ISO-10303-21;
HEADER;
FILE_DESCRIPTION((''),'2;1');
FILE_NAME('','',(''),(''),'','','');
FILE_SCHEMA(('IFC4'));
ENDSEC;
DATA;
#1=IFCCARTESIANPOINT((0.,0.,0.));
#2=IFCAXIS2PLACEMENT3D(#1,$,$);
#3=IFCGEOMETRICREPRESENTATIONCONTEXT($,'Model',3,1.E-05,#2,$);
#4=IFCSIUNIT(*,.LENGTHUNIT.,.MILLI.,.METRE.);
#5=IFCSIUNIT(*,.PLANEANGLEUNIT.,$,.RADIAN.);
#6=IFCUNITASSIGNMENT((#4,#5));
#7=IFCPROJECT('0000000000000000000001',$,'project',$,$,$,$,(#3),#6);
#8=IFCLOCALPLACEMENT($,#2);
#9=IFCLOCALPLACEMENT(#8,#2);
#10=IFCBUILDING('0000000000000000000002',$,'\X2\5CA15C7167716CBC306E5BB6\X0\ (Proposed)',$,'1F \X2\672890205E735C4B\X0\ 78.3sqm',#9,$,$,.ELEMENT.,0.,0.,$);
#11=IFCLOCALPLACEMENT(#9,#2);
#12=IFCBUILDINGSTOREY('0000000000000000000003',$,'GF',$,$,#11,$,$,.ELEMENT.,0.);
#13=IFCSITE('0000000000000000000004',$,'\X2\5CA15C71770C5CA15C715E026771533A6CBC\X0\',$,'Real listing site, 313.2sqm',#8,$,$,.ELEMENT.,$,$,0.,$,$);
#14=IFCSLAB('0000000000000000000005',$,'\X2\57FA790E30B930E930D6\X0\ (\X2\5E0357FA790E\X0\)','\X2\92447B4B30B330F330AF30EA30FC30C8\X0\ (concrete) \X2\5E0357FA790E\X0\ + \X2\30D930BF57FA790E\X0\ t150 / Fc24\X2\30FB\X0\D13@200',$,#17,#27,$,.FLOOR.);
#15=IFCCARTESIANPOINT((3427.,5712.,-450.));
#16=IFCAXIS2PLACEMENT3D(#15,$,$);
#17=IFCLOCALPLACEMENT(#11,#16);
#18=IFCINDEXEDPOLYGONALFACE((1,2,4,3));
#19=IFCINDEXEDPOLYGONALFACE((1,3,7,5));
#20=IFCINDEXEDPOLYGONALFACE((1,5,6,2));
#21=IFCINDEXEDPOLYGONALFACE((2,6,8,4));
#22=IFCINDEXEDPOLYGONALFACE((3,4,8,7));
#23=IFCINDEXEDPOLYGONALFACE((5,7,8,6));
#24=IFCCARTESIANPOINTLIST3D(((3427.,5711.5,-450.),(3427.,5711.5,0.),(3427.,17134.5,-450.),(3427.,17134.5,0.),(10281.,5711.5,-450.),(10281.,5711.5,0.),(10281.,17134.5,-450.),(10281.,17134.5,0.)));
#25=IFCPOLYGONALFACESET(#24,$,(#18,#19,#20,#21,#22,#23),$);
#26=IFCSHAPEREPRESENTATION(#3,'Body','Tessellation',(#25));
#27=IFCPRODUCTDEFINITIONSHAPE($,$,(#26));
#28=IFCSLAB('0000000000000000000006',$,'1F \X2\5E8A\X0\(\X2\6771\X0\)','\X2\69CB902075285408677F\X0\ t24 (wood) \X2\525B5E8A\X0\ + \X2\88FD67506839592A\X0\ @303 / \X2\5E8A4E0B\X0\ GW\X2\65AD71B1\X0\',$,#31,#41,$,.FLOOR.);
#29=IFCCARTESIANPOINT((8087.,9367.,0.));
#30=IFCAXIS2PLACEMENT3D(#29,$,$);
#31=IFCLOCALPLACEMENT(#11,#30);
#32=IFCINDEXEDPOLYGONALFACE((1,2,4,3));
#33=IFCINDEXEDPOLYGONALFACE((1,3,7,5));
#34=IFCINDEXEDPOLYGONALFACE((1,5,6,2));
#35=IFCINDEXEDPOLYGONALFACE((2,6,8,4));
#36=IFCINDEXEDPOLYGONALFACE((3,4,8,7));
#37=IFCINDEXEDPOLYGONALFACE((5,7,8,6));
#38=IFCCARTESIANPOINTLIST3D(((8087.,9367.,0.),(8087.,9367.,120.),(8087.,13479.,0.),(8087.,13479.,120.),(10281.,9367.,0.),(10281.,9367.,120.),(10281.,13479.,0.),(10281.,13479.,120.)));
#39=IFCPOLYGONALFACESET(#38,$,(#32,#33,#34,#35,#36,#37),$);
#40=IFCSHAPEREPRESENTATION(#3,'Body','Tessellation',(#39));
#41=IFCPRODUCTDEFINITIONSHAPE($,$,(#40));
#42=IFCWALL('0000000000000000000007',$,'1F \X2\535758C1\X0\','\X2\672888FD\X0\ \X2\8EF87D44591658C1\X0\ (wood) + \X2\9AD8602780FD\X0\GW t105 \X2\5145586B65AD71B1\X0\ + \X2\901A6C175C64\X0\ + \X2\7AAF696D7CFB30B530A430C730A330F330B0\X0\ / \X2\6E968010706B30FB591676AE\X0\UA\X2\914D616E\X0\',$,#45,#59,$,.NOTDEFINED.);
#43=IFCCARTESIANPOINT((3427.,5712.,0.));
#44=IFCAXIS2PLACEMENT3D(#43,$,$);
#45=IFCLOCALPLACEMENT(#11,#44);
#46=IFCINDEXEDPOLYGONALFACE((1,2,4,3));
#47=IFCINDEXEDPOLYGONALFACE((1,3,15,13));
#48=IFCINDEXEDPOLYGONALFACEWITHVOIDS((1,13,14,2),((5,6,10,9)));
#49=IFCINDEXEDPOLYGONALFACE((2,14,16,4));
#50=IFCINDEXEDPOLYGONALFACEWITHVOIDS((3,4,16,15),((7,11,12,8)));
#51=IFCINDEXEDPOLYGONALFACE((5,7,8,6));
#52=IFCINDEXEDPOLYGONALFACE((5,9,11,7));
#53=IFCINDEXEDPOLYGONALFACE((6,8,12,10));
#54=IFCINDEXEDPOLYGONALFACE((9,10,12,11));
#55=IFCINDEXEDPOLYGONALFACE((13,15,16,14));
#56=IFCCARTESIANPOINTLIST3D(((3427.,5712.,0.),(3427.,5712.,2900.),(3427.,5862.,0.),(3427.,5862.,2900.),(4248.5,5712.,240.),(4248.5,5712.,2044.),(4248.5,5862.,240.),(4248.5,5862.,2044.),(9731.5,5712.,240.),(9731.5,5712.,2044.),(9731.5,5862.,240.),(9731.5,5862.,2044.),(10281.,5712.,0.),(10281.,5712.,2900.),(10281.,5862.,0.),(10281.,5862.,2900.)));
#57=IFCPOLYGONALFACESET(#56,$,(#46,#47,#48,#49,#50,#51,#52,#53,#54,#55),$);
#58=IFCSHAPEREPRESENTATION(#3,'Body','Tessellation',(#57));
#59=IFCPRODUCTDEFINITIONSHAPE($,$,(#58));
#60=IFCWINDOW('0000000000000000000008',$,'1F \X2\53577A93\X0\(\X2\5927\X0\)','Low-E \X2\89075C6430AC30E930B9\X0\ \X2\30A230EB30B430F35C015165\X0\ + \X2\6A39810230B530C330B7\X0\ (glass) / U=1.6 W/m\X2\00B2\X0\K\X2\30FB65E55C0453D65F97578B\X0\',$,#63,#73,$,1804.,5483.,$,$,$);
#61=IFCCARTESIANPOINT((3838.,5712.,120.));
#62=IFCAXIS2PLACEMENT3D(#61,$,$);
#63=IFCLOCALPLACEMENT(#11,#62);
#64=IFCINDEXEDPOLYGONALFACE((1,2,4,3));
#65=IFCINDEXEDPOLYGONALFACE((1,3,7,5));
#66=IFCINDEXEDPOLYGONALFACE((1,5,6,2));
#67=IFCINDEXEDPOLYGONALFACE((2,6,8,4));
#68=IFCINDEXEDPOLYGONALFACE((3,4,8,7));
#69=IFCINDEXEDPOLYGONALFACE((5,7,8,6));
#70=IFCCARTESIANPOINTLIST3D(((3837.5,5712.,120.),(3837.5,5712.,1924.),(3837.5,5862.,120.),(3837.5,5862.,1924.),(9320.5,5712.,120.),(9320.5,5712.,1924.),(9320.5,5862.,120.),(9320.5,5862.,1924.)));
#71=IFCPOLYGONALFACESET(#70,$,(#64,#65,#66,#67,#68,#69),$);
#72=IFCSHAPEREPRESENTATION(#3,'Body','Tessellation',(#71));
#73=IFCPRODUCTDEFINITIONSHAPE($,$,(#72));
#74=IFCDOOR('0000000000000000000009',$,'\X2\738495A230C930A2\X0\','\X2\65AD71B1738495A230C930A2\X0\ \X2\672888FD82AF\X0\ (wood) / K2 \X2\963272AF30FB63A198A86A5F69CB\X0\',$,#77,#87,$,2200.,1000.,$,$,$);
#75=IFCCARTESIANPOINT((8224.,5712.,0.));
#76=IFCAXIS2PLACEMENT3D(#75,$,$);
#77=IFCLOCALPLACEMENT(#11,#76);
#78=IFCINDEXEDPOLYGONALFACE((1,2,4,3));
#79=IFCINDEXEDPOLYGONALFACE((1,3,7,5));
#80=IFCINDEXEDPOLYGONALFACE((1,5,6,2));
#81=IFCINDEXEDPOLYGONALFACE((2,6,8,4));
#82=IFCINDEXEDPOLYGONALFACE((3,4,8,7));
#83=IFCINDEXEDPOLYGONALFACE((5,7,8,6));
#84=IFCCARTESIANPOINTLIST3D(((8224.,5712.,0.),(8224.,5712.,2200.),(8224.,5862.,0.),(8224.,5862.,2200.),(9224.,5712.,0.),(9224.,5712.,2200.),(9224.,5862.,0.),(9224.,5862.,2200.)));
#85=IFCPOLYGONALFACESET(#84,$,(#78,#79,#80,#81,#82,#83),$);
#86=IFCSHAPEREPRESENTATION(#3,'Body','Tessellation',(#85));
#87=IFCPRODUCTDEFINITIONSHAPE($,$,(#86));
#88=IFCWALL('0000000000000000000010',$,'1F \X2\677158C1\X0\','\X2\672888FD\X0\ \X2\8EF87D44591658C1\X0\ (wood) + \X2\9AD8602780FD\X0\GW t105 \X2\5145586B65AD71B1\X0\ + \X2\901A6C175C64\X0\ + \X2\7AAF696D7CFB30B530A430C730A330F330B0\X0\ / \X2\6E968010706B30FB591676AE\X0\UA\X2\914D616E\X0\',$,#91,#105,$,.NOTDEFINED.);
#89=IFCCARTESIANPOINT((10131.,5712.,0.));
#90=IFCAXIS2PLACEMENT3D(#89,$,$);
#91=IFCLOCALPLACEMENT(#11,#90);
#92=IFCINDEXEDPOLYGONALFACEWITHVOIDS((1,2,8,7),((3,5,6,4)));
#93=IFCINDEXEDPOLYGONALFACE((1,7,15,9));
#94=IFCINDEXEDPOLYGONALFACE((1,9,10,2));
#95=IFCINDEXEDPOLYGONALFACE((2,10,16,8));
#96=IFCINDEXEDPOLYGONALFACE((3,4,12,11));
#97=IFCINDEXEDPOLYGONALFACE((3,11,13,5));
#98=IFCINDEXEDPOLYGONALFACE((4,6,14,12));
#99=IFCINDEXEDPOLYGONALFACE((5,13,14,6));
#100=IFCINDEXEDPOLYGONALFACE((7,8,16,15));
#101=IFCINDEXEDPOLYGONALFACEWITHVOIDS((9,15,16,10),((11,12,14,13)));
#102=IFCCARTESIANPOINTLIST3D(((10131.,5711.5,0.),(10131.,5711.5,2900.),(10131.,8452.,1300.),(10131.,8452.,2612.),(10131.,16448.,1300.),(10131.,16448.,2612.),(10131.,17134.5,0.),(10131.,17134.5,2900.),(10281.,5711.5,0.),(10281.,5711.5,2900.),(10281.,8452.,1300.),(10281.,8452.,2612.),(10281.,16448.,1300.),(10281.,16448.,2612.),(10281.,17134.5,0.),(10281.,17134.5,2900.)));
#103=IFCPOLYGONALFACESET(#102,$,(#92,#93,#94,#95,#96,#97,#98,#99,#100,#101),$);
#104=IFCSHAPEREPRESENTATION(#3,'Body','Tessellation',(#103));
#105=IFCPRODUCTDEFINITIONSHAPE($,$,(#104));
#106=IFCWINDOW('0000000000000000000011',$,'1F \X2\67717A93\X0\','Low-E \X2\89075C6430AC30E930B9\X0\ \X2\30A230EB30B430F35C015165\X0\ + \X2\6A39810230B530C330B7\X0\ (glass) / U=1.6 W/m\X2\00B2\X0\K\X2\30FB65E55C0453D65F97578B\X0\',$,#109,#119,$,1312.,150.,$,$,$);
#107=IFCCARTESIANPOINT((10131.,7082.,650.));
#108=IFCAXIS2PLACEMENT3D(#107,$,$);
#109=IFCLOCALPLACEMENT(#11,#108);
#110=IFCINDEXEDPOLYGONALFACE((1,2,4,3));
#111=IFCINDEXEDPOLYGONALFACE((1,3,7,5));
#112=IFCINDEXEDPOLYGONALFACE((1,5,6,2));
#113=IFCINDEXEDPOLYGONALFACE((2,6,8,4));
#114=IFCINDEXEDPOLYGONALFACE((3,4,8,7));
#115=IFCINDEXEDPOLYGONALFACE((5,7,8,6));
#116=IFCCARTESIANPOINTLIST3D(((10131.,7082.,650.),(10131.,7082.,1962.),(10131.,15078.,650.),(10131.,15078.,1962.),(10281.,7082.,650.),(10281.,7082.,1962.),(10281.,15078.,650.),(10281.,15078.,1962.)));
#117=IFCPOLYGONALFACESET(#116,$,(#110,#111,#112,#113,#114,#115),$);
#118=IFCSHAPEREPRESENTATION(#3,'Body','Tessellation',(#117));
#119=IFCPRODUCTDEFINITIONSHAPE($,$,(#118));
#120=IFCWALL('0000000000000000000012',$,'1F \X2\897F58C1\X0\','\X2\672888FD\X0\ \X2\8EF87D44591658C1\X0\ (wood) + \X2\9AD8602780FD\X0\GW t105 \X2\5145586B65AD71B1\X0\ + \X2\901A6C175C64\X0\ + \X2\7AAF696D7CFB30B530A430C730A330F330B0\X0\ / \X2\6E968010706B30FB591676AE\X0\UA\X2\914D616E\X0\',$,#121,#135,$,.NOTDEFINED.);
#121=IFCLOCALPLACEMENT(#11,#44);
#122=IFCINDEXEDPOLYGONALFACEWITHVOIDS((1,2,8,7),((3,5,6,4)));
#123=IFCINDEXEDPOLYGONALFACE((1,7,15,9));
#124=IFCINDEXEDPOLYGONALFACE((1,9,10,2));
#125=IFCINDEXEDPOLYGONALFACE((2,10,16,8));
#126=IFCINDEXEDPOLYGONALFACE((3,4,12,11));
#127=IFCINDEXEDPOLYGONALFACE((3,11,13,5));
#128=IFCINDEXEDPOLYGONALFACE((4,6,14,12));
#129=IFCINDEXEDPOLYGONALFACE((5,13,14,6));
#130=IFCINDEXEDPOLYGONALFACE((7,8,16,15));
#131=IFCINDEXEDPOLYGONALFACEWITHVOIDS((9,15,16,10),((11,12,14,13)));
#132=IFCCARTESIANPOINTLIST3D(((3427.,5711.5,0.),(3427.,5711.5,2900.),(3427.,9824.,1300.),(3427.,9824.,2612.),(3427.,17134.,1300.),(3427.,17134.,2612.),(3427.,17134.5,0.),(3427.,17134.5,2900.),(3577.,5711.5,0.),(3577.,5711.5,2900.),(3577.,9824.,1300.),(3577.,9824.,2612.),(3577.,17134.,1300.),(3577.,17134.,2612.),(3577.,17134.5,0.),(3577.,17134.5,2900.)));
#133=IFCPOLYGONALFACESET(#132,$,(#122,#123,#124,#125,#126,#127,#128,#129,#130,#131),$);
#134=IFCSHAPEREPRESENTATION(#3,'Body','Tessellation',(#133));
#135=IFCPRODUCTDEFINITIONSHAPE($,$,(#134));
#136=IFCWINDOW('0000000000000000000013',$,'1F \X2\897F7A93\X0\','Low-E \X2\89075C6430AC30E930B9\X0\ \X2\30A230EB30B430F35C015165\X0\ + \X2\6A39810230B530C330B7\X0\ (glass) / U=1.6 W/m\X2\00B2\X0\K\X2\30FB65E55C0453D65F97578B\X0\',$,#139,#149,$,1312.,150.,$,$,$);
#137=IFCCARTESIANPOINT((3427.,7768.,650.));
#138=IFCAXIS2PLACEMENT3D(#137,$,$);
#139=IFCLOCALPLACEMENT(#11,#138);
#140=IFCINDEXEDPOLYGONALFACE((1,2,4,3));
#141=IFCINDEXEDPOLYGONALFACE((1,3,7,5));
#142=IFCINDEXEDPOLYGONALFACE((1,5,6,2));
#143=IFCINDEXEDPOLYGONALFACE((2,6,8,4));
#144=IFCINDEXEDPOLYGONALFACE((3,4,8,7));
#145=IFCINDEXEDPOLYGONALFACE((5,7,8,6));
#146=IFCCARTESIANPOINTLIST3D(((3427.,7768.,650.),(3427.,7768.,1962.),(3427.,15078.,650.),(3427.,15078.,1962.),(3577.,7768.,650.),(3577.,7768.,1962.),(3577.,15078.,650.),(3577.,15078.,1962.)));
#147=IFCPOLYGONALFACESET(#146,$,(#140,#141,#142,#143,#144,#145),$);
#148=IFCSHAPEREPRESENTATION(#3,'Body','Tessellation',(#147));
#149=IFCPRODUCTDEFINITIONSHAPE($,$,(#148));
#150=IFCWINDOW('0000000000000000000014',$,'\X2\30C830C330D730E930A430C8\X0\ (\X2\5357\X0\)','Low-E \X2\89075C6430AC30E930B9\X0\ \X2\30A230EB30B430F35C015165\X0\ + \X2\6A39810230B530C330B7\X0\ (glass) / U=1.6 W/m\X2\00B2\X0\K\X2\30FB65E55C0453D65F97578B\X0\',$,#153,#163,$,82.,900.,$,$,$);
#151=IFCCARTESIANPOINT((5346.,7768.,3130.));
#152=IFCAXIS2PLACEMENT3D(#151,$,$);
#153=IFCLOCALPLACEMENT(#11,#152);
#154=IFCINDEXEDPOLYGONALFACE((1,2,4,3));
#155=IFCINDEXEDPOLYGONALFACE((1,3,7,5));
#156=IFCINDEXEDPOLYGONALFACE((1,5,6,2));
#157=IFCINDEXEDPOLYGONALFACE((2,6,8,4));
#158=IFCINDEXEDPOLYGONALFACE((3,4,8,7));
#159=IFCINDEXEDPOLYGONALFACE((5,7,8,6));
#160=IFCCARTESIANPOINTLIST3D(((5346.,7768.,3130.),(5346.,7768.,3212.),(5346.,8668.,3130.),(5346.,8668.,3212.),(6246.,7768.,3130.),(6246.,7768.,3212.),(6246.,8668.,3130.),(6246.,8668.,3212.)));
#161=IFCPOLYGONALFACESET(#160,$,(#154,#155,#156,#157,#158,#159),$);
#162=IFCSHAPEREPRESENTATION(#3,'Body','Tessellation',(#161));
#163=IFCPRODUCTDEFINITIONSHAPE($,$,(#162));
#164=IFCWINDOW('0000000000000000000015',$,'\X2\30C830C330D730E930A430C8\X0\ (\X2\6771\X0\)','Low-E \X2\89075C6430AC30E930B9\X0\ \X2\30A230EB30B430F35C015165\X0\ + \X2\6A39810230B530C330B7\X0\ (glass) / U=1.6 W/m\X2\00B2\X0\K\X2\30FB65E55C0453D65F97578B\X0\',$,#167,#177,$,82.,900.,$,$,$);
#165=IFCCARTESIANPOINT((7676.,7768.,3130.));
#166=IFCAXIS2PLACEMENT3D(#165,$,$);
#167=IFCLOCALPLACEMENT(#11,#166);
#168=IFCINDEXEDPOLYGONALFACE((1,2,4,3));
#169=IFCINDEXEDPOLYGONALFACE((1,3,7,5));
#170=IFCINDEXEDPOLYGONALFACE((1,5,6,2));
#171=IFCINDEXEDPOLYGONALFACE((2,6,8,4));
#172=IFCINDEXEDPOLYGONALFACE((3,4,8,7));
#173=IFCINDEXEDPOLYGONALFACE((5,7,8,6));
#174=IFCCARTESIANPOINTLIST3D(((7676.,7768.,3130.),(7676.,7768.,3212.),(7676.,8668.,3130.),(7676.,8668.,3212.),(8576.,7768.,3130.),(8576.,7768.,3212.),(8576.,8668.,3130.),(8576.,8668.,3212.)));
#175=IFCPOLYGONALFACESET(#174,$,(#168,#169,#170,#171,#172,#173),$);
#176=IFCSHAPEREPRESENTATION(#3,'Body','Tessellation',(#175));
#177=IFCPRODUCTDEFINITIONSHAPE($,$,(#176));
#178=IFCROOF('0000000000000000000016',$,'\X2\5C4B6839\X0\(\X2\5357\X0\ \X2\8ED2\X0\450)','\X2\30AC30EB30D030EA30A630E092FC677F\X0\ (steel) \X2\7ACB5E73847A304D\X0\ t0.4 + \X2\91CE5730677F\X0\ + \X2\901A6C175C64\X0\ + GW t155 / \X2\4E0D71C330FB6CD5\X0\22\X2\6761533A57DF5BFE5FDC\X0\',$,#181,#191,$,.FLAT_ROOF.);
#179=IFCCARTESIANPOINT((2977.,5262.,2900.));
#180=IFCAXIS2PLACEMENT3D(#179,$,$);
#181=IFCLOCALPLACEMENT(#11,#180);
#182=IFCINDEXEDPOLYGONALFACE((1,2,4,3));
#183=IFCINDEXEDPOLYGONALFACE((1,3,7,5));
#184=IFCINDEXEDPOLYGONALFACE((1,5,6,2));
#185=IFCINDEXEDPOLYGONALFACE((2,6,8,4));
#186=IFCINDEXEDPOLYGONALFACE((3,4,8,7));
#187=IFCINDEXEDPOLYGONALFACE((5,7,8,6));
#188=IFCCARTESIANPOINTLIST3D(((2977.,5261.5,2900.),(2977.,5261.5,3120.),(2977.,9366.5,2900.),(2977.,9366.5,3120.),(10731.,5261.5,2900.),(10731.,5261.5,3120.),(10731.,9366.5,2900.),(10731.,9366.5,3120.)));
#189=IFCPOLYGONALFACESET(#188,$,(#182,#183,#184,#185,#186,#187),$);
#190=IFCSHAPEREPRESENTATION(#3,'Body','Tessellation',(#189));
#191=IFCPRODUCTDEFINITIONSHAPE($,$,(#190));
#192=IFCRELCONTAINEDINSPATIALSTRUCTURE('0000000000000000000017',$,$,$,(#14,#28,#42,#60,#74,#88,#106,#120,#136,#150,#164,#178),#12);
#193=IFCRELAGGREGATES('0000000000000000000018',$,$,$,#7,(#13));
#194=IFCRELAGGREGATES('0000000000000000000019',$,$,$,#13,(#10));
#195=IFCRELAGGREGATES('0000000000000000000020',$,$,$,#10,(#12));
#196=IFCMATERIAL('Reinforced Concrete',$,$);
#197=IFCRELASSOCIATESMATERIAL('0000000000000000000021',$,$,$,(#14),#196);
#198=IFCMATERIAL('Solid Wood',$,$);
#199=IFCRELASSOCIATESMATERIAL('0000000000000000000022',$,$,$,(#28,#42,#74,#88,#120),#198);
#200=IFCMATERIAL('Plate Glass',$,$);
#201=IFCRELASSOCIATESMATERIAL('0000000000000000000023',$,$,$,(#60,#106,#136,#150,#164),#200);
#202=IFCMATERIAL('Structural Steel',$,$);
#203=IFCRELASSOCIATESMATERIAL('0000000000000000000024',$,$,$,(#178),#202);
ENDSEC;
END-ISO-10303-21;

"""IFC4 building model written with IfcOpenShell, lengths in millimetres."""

from ifc_helpers import new_model, si_unit, frame, frame_2d, origin, place, context, project, spatial, rectangle, extrude, material, element, fill, save


model = new_model("IFC4")

# Units and contexts
model_context = context("Model", 3, precision=1e-05, world=origin())
ifc_project = project(units=[si_unit("LENGTHUNIT", "METRE", prefix="MILLI"), si_unit("PLANEANGLEUNIT", "RADIAN")], contexts=[model_context])

# Site, building, storey
site_placement = place(None, origin())
site = spatial("IfcSite", under=ifc_project, at=site_placement, Name="岡山県岡山市東区沼", ObjectType="Real listing site, 313.2sqm", CompositionType="ELEMENT", RefElevation=0.0)
building_placement = place(site_placement, origin())
building = spatial("IfcBuilding", under=site, at=building_placement, Name="岡山東沼の家 (Proposed)", ObjectType="1F 木造平屋 78.3sqm", CompositionType="ELEMENT", ElevationOfRefHeight=0.0, ElevationOfTerrain=0.0)
storey_placement = place(building_placement, origin())
storey = spatial("IfcBuildingStorey", under=building, at=storey_placement, Name="GF", CompositionType="ELEMENT", Elevation=0.0)

# Slabs
ifc_material_1 = material(Name="Reinforced Concrete")
slab_1_placement = place(storey_placement, frame((3427.0, 5712.0, -450.0)))
element("IfcSlab", 1, at=slab_1_placement, inside=storey, material=ifc_material_1, Name="基礎スラブ (布基礎)", Description="鉄筋コンクリート (concrete) 布基礎 + ベタ基礎 t150 / Fc24・D13@200", PredefinedType="FLOOR", context=model_context, shape_type="SweptSolid", body=[
    extrude(rectangle(XDim=6854.0, YDim=11423.0, at=frame_2d((3427.0, 5711.0))), frame((3427.0, 5712.0, -450.0)), (0.0, 0.0, 1.0), 450.0),
])
ifc_material_2 = material(Name="Solid Wood")
slab_2_placement = place(storey_placement, frame((8087.0, 9367.0, 0.0)))
element("IfcSlab", 2, at=slab_2_placement, inside=storey, material=ifc_material_2, Name="1F 床(東)", Description="構造用合板 t24 (wood) 剛床 + 製材根太 @303 / 床下 GW断熱", PredefinedType="FLOOR", context=model_context, shape_type="SweptSolid", body=[
    extrude(rectangle(XDim=2194.0, YDim=4112.0, at=frame_2d((1097.0, 2056.0))), frame((8087.0, 9367.0, 0.0)), (0.0, 0.0, 1.0), 120.0),
])

# Wall, openings, window, door
wall_1_placement = place(storey_placement, frame((3427.0, 5712.0, 0.0)))
wall_1 = element("IfcWall", 3, at=wall_1_placement, inside=storey, material=ifc_material_2, Name="1F 南壁", Description="木製 軸組外壁 (wood) + 高性能GW t105 充填断熱 + 通気層 + 窯業系サイディング / 準耐火・外皮UA配慮", PredefinedType="NOTDEFINED", context=model_context, shape_type="SweptSolid", body=[
    extrude(rectangle(XDim=6854.0, YDim=150.0, at=frame_2d((3427.0, 75.0))), frame((3427.0, 5712.0, 0.0)), (0.0, 0.0, 1.0), 2900.0),
])
opening_1_placement = place(storey_placement, frame((3838.0, 5712.0, 120.0)))
opening_1 = element("IfcOpeningElement", 4, at=opening_1_placement, cuts=wall_1, PredefinedType="NOTDEFINED", context=model_context, shape_type="SweptSolid", body=[
    extrude(rectangle(XDim=5483.0, YDim=150.0, at=frame_2d((2741.0, 75.0))), frame((3838.0, 5712.0, 120.0)), (0.0, 0.0, 1.0), 1804.0),
])
opening_2_placement = place(storey_placement, frame((8224.0, 5712.0, 0.0)))
opening_2 = element("IfcOpeningElement", 5, at=opening_2_placement, cuts=wall_1, PredefinedType="NOTDEFINED", context=model_context, shape_type="SweptSolid", body=[
    extrude(rectangle(XDim=1000.0, YDim=150.0, at=frame_2d((500.0, 75.0))), frame((8224.0, 5712.0, 0.0)), (0.0, 0.0, 1.0), 2200.0),
])
ifc_material_3 = material(Name="Plate Glass")
window_1_placement = place(storey_placement, frame((3838.0, 5712.0, 120.0)))
window_1 = element("IfcWindow", 6, at=window_1_placement, inside=storey, material=ifc_material_3, Name="1F 南窓(大)", Description="Low-E 複層ガラス アルゴン封入 + 樹脂サッシ (glass) / U=1.6 W/m²K・日射取得型", OverallHeight=1804.0, OverallWidth=5483.0, context=model_context, shape_type="SweptSolid", body=[
    extrude(rectangle(XDim=5483.0, YDim=150.0, at=frame_2d((2741.0, 75.0))), frame((3838.0, 5712.0, 120.0)), (0.0, 0.0, 1.0), 1804.0),
])
fill(opening_1, window_1)
door_placement = place(storey_placement, frame((8224.0, 5712.0, 0.0)))
door = element("IfcDoor", 7, at=door_placement, inside=storey, material=ifc_material_2, Name="玄関ドア", Description="断熱玄関ドア 木製芯 (wood) / K2 防犯・採風機構", OverallHeight=2200.0, OverallWidth=1000.0, context=model_context, shape_type="SweptSolid", body=[
    extrude(rectangle(XDim=1000.0, YDim=150.0, at=frame_2d((500.0, 75.0))), frame((8224.0, 5712.0, 0.0)), (0.0, 0.0, 1.0), 2200.0),
])
fill(opening_2, door)

# Walls, openings, windows
wall_2_placement = place(storey_placement, frame((10131.0, 5712.0, 0.0)))
wall_2 = element("IfcWall", 8, at=wall_2_placement, inside=storey, material=ifc_material_2, Name="1F 東壁", Description="木製 軸組外壁 (wood) + 高性能GW t105 充填断熱 + 通気層 + 窯業系サイディング / 準耐火・外皮UA配慮", PredefinedType="NOTDEFINED", context=model_context, shape_type="SweptSolid", body=[
    extrude(rectangle(XDim=150.0, YDim=11423.0, at=frame_2d((75.0, 5711.0))), frame((10131.0, 5712.0, 0.0)), (0.0, 0.0, 1.0), 2900.0),
])
opening_3_placement = place(storey_placement, frame((10131.0, 7082.0, 650.0)))
opening_3 = element("IfcOpeningElement", 9, at=opening_3_placement, cuts=wall_2, PredefinedType="NOTDEFINED", context=model_context, shape_type="SweptSolid", body=[
    extrude(rectangle(XDim=150.0, YDim=7996.0, at=frame_2d((75.0, 3998.0))), frame((10131.0, 7082.0, 650.0)), (0.0, 0.0, 1.0), 1312.0),
])
window_2_placement = place(storey_placement, frame((10131.0, 7082.0, 650.0)))
window_2 = element("IfcWindow", 10, at=window_2_placement, inside=storey, material=ifc_material_3, Name="1F 東窓", Description="Low-E 複層ガラス アルゴン封入 + 樹脂サッシ (glass) / U=1.6 W/m²K・日射取得型", OverallHeight=1312.0, OverallWidth=150.0, context=model_context, shape_type="SweptSolid", body=[
    extrude(rectangle(XDim=150.0, YDim=7996.0, at=frame_2d((75.0, 3998.0))), frame((10131.0, 7082.0, 650.0)), (0.0, 0.0, 1.0), 1312.0),
])
fill(opening_3, window_2)
wall_3_placement = place(storey_placement, frame((3427.0, 5712.0, 0.0)))
wall_3 = element("IfcWall", 11, at=wall_3_placement, inside=storey, material=ifc_material_2, Name="1F 西壁", Description="木製 軸組外壁 (wood) + 高性能GW t105 充填断熱 + 通気層 + 窯業系サイディング / 準耐火・外皮UA配慮", PredefinedType="NOTDEFINED", context=model_context, shape_type="SweptSolid", body=[
    extrude(rectangle(XDim=150.0, YDim=11423.0, at=frame_2d((75.0, 5711.0))), frame((3427.0, 5712.0, 0.0)), (0.0, 0.0, 1.0), 2900.0),
])
opening_4_placement = place(storey_placement, frame((3427.0, 7768.0, 650.0)))
opening_4 = element("IfcOpeningElement", 12, at=opening_4_placement, cuts=wall_3, PredefinedType="NOTDEFINED", context=model_context, shape_type="SweptSolid", body=[
    extrude(rectangle(XDim=150.0, YDim=7310.0, at=frame_2d((75.0, 3655.0))), frame((3427.0, 7768.0, 650.0)), (0.0, 0.0, 1.0), 1312.0),
])
window_3_placement = place(storey_placement, frame((3427.0, 7768.0, 650.0)))
window_3 = element("IfcWindow", 13, at=window_3_placement, inside=storey, material=ifc_material_3, Name="1F 西窓", Description="Low-E 複層ガラス アルゴン封入 + 樹脂サッシ (glass) / U=1.6 W/m²K・日射取得型", OverallHeight=1312.0, OverallWidth=150.0, context=model_context, shape_type="SweptSolid", body=[
    extrude(rectangle(XDim=150.0, YDim=7310.0, at=frame_2d((75.0, 3655.0))), frame((3427.0, 7768.0, 650.0)), (0.0, 0.0, 1.0), 1312.0),
])
fill(opening_4, window_3)

# Windows
window_4_placement = place(storey_placement, frame((5346.0, 7768.0, 3130.0)))
element("IfcWindow", 14, at=window_4_placement, inside=storey, material=ifc_material_3, Name="トップライト (南)", Description="Low-E 複層ガラス アルゴン封入 + 樹脂サッシ (glass) / U=1.6 W/m²K・日射取得型", OverallHeight=82.0, OverallWidth=900.0, context=model_context, shape_type="SweptSolid", body=[
    extrude(rectangle(XDim=900.0, YDim=900.0, at=frame_2d((450.0, 450.0))), frame((5346.0, 7768.0, 3130.0)), (0.0, 0.0, 1.0), 82.0),
])
window_5_placement = place(storey_placement, frame((7676.0, 7768.0, 3130.0)))
element("IfcWindow", 15, at=window_5_placement, inside=storey, material=ifc_material_3, Name="トップライト (東)", Description="Low-E 複層ガラス アルゴン封入 + 樹脂サッシ (glass) / U=1.6 W/m²K・日射取得型", OverallHeight=82.0, OverallWidth=900.0, context=model_context, shape_type="SweptSolid", body=[
    extrude(rectangle(XDim=900.0, YDim=900.0, at=frame_2d((450.0, 450.0))), frame((7676.0, 7768.0, 3130.0)), (0.0, 0.0, 1.0), 82.0),
])

# Roof
ifc_material_4 = material(Name="Structural Steel")
roof_placement = place(storey_placement, frame((2977.0, 5262.0, 2900.0)))
element("IfcRoof", 16, at=roof_placement, inside=storey, material=ifc_material_4, Name="屋根(南 軒450)", Description="ガルバリウム鋼板 (steel) 立平葺き t0.4 + 野地板 + 通気層 + GW t155 / 不燃・法22条区域対応", PredefinedType="FLAT_ROOF", context=model_context, shape_type="SweptSolid", body=[
    extrude(rectangle(XDim=7754.0, YDim=4105.0, at=frame_2d((3877.0, 2052.0))), frame((2977.0, 5262.0, 2900.0)), (0.0, 0.0, 1.0), 220.0),
])

save(model, "model.ifc")
